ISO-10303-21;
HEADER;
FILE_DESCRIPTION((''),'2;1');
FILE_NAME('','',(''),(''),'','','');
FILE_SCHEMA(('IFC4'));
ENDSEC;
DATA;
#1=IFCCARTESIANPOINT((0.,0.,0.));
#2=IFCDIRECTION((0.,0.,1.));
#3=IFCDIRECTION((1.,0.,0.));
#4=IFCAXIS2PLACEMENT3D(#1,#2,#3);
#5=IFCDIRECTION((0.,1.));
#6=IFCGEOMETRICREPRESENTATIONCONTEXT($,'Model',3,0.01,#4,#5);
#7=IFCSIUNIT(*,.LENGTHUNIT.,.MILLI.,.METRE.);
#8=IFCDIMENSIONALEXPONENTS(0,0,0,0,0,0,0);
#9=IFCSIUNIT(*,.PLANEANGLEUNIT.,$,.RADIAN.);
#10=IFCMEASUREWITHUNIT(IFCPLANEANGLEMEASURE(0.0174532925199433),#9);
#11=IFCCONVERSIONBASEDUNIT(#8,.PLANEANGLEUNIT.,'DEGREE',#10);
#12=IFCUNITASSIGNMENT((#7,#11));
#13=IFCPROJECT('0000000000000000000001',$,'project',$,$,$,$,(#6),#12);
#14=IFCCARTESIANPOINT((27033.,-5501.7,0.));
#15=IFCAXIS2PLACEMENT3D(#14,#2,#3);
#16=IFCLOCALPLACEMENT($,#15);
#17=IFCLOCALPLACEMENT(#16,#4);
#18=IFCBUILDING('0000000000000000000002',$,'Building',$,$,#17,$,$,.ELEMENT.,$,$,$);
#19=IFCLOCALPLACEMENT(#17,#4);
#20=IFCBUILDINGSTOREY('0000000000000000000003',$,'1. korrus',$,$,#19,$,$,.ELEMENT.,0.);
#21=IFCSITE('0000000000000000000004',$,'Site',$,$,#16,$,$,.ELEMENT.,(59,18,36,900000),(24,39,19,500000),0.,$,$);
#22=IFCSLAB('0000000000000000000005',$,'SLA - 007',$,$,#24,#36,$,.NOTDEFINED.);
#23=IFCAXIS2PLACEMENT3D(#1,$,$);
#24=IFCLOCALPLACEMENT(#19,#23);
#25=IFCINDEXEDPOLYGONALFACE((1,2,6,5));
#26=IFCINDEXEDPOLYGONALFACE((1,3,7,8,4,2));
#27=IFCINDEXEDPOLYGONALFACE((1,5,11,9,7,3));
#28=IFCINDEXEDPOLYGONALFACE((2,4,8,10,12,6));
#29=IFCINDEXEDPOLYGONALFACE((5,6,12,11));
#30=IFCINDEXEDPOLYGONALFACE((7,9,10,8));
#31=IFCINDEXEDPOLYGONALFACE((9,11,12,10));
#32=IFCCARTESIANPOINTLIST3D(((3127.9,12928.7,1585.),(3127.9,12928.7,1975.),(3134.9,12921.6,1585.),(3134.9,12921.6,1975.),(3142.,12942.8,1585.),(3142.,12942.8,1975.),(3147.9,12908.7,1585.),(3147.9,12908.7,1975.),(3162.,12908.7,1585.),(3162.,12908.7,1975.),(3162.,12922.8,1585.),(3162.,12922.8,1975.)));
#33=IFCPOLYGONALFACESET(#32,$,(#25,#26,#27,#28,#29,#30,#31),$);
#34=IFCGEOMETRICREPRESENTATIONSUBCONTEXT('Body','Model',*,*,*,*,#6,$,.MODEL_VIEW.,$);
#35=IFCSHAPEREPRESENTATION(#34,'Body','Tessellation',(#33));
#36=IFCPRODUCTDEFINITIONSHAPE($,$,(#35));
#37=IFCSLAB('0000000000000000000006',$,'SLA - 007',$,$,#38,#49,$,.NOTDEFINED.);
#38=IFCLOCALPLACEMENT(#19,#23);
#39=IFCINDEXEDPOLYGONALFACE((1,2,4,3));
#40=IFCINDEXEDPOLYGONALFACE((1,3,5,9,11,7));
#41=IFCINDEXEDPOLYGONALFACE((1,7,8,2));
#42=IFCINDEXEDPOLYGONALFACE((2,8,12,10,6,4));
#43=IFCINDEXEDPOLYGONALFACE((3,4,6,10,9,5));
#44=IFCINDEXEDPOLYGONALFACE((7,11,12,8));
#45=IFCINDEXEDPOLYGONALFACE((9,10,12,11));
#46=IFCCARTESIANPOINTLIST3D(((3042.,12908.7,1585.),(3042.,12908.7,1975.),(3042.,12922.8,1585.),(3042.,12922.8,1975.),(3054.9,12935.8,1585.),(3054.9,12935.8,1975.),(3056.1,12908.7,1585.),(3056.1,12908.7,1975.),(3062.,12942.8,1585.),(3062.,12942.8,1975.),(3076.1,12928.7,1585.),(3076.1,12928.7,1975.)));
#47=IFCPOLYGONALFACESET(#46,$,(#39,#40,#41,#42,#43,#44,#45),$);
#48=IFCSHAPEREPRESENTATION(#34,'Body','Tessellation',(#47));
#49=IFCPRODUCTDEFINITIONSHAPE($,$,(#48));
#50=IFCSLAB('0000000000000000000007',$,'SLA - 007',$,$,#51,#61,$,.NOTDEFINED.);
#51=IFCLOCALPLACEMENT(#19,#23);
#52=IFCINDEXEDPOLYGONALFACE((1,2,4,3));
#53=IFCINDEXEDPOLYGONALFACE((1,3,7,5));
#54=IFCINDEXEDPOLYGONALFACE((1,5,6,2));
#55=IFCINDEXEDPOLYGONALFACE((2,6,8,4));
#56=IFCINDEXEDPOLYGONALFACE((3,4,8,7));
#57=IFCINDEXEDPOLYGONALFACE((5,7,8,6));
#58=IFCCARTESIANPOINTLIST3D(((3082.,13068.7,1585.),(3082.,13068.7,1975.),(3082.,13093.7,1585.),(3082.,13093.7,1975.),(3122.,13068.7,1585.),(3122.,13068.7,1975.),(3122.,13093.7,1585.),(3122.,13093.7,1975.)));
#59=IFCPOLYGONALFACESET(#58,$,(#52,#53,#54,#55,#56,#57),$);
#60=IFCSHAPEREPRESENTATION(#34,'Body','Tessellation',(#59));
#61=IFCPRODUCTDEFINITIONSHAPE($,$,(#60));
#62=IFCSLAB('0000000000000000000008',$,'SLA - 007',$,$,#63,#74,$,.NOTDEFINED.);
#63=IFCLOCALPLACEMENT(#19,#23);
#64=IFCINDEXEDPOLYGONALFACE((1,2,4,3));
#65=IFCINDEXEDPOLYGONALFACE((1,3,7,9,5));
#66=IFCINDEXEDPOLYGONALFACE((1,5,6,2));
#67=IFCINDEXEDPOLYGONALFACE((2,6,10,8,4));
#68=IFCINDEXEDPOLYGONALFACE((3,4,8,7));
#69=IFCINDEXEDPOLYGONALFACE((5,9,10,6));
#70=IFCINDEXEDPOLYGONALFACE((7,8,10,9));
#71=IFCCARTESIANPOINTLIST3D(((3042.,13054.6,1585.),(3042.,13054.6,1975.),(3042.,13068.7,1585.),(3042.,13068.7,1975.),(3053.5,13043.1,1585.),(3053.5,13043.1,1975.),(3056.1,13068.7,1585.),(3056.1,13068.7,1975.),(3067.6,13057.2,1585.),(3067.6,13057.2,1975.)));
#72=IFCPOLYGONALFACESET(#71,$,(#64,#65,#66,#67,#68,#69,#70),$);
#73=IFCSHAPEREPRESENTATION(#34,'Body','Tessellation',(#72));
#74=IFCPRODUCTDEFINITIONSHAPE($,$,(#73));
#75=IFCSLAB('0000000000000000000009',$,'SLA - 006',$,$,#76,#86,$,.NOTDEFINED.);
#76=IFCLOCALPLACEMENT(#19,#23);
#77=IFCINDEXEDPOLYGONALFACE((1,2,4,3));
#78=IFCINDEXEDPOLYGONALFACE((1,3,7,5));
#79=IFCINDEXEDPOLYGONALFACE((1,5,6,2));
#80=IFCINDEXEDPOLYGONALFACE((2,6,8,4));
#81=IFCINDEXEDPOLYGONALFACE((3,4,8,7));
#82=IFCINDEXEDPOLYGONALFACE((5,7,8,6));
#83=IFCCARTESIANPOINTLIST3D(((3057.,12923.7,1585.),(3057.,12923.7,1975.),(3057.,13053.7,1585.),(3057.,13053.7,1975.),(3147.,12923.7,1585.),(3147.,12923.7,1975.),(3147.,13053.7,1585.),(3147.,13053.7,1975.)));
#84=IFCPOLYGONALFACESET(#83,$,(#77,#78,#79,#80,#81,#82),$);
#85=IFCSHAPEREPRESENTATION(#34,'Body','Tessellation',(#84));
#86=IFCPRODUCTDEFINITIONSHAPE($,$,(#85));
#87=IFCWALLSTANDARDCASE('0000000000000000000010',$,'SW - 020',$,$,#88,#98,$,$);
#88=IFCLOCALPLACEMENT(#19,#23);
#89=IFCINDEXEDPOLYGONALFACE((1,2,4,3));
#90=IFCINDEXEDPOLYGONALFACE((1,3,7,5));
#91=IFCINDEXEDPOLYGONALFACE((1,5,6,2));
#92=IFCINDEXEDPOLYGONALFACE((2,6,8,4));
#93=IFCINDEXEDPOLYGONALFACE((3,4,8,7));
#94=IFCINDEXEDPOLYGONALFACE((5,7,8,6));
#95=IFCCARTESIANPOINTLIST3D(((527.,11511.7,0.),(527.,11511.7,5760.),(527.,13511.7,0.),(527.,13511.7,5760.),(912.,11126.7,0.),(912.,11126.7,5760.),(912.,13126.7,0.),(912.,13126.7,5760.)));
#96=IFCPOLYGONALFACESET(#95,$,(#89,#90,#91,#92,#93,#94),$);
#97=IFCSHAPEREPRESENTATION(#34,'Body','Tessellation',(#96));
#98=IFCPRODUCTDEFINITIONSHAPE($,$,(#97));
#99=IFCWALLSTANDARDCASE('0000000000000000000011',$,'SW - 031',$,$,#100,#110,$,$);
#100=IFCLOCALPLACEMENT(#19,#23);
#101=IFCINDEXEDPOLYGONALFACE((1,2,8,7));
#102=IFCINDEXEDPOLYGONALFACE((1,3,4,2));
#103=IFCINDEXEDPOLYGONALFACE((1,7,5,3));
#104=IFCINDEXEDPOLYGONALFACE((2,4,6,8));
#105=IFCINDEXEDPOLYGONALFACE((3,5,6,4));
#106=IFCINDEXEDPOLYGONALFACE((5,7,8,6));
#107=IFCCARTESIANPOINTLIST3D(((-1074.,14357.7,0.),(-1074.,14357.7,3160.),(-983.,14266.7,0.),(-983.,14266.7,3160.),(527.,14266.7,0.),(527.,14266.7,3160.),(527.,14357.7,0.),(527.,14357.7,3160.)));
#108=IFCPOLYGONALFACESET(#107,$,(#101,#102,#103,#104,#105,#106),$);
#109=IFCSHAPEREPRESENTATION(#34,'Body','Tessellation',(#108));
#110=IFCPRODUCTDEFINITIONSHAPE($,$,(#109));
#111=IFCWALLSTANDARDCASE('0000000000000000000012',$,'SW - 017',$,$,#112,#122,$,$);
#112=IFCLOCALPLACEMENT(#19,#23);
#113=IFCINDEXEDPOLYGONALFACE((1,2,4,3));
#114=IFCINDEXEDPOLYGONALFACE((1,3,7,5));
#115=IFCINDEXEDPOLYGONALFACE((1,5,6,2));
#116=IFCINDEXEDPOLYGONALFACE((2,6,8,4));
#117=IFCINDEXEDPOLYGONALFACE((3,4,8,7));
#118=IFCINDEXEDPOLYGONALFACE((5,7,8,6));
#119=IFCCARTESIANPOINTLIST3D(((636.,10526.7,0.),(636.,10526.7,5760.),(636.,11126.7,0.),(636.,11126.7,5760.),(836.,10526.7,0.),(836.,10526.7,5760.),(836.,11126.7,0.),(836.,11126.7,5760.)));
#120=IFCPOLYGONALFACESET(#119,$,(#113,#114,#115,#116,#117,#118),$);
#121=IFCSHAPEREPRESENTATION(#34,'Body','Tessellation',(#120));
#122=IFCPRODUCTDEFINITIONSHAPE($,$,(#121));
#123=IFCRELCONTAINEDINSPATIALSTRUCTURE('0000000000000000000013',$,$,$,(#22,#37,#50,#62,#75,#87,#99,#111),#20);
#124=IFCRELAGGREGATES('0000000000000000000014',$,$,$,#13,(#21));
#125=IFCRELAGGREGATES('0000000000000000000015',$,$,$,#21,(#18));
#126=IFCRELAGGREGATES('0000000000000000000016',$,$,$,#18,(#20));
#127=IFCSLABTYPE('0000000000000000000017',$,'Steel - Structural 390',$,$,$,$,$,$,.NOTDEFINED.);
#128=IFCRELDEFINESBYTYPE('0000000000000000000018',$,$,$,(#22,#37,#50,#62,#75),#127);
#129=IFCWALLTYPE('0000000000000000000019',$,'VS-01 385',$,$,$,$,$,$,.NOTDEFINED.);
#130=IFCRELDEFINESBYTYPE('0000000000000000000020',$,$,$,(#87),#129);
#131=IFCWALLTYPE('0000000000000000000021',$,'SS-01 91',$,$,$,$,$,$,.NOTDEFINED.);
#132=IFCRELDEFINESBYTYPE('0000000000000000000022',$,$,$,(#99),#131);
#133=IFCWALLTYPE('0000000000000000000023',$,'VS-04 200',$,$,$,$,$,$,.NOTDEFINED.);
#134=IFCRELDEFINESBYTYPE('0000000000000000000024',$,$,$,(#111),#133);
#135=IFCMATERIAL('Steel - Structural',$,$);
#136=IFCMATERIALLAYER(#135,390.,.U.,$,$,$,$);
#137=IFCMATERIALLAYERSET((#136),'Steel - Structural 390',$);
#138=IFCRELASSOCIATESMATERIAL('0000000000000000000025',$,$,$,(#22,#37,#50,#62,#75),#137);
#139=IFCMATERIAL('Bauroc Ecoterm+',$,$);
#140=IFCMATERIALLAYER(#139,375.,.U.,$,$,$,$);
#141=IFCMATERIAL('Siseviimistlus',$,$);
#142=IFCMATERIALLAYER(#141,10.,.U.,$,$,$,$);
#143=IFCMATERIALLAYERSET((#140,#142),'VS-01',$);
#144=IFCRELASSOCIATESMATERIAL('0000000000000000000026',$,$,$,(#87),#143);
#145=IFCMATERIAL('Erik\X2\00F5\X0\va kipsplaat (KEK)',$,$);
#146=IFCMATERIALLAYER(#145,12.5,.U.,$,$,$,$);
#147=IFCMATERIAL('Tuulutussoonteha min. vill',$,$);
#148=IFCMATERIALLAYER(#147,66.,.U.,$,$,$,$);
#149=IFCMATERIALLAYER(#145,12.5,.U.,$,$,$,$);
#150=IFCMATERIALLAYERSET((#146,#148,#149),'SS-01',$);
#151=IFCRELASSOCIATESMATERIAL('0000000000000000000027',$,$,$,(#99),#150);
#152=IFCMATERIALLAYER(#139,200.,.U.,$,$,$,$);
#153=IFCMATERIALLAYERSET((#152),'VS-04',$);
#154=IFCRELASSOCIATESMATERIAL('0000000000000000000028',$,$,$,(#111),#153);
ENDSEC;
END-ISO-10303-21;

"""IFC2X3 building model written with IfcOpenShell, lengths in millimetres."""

from ifc_helpers import new_model, entity, si_unit, converted_unit, direction, frame, origin_with_axes, place, context, subcontext, project, spatial, polyline, outline, extrude, material, layer, layer_set, layer_usage, type_object, element, save


model = new_model("IFC2X3")

# Units and contexts
model_context = context("Model", 3, precision=0.01, world=origin_with_axes(), true_north=direction((0.0, 1.0)))
body_context = subcontext(model_context, "Body", "Model", "MODEL_VIEW")
ifc_project = project(units=[si_unit("LENGTHUNIT", "METRE", prefix="MILLI"), converted_unit("PLANEANGLEUNIT", "DEGREE", entity("IfcPlaneAngleMeasure", 0.0174532925199433), si_unit("PLANEANGLEUNIT", "RADIAN"), dimensions=[0, 0, 0, 0, 0, 0, 0])], contexts=[model_context])

# Site, building, storey
site_placement = place(None, frame((27033.0, -5501.7, 0.0), z_axis=(0.0, 0.0, 1.0), x_axis=(1.0, 0.0, 0.0)))
site = spatial("IfcSite", under=ifc_project, at=site_placement, Name="Site", CompositionType="ELEMENT", RefLatitude=(59, 18, 36, 900000), RefLongitude=(24, 39, 19, 500000), RefElevation=0.0)
building_placement = place(site_placement, origin_with_axes())
building = spatial("IfcBuilding", under=site, at=building_placement, Name="Building", CompositionType="ELEMENT")
storey_placement = place(building_placement, origin_with_axes())
storey = spatial("IfcBuildingStorey", under=building, at=storey_placement, Name="1. korrus", CompositionType="ELEMENT", Elevation=0.0)

# Slabs
ifc_material_1 = material(Name="Steel - Structural")
ifc_layer_1 = layer(ifc_material_1, 390.0, ventilated="UNKNOWN")
ifc_layer_set_1 = layer_set([ifc_layer_1], Name="Steel - Structural 390")
ifc_layer_usage_1 = layer_usage(ifc_layer_set_1, "AXIS3", "NEGATIVE", 390.0)
slab_type = type_object("IfcSlabType", Name="Steel - Structural 390", PredefinedType="NOTDEFINED")
slab_1_placement = place(storey_placement, frame((3134.9, 12921.6, 1585.0), z_axis=(0.0, 0.0, 1.0), x_axis=(1.0, 0.0, 0.0)))
element("IfcSlab", 1, at=slab_1_placement, inside=storey, type_object=slab_type, material=ifc_layer_usage_1, Name="SLA - 007", PredefinedType="NOTDEFINED", context=body_context, shape_type="SweptSolid", body=[
    extrude(outline(polyline([(0.0, 0.0), (12.9, -12.9), (27.1, -12.9), (27.1, 1.2), (7.1, 21.2), (-7.1, 7.1), (0.0, 0.0)])), origin_with_axes(), (0.0, 0.0, 1.0), 390.0),
])
ifc_layer_usage_2 = layer_usage(ifc_layer_set_1, "AXIS3", "NEGATIVE", 390.0)
slab_2_placement = place(storey_placement, frame((3054.9, 12935.8, 1585.0), z_axis=(0.0, 0.0, 1.0), x_axis=(1.0, 0.0, 0.0)))
element("IfcSlab", 2, at=slab_2_placement, inside=storey, type_object=slab_type, material=ifc_layer_usage_2, Name="SLA - 007", PredefinedType="NOTDEFINED", context=body_context, shape_type="SweptSolid", body=[
    extrude(outline(polyline([(0.0, 0.0), (-12.9, -12.9), (-12.9, -27.1), (1.2, -27.1), (21.2, -7.1), (7.1, 7.1), (0.0, 0.0)])), origin_with_axes(), (0.0, 0.0, 1.0), 390.0),
])
ifc_layer_usage_3 = layer_usage(ifc_layer_set_1, "AXIS3", "NEGATIVE", 390.0)
slab_3_placement = place(storey_placement, frame((3082.0, 13068.7, 1585.0), z_axis=(0.0, 0.0, 1.0), x_axis=(1.0, 0.0, 0.0)))
element("IfcSlab", 3, at=slab_3_placement, inside=storey, type_object=slab_type, material=ifc_layer_usage_3, Name="SLA - 007", PredefinedType="NOTDEFINED", context=body_context, shape_type="SweptSolid", body=[
    extrude(outline(polyline([(0.0, 0.0), (40.0, 0.0), (40.0, 25.0), (0.0, 25.0), (0.0, 0.0)])), origin_with_axes(), (0.0, 0.0, 1.0), 390.0),
])
ifc_layer_usage_4 = layer_usage(ifc_layer_set_1, "AXIS3", "NEGATIVE", 390.0)
slab_4_placement = place(storey_placement, frame((3053.5, 13043.1, 1585.0), z_axis=(0.0, 0.0, 1.0), x_axis=(1.0, 0.0, 0.0)))
element("IfcSlab", 4, at=slab_4_placement, inside=storey, type_object=slab_type, material=ifc_layer_usage_4, Name="SLA - 007", PredefinedType="NOTDEFINED", context=body_context, shape_type="SweptSolid", body=[
    extrude(outline(polyline([(0.0, 0.0), (14.1, 14.1), (2.7, 25.6), (-11.5, 25.6), (-11.5, 11.5), (0.0, 0.0)])), origin_with_axes(), (0.0, 0.0, 1.0), 390.0),
])
ifc_layer_usage_5 = layer_usage(ifc_layer_set_1, "AXIS3", "NEGATIVE", 390.0)
slab_5_placement = place(storey_placement, frame((3147.0, 13053.7, 1585.0), z_axis=(0.0, 0.0, 1.0), x_axis=(1.0, 0.0, 0.0)))
element("IfcSlab", 5, at=slab_5_placement, inside=storey, type_object=slab_type, material=ifc_layer_usage_5, Name="SLA - 006", PredefinedType="NOTDEFINED", context=body_context, shape_type="SweptSolid", body=[
    extrude(outline(polyline([(0.0, 0.0), (-90.0, 0.0), (-90.0, -130.0), (0.0, -130.0), (0.0, 0.0)])), origin_with_axes(), (0.0, 0.0, 1.0), 390.0),
])

# Wall
ifc_material_2 = material(Name="Bauroc Ecoterm+")
ifc_layer_2 = layer(ifc_material_2, 375.0, ventilated="UNKNOWN")
ifc_material_3 = material(Name="Siseviimistlus")
ifc_layer_3 = layer(ifc_material_3, 10.0, ventilated="UNKNOWN")
ifc_layer_set_2 = layer_set([ifc_layer_2, ifc_layer_3], Name="VS-01")
ifc_layer_usage_6 = layer_usage(ifc_layer_set_2, "AXIS2", "POSITIVE", -385.0)
wall_type_1 = type_object("IfcWallType", Name="VS-01 385", PredefinedType="NOTDEFINED")
wall_1_placement = place(storey_placement, frame((527.0, 11511.7, 0.0), z_axis=(0.0, 0.0, 1.0), x_axis=(0.000026, 1.0, 0.0)))
element("IfcWallStandardCase", 6, at=wall_1_placement, inside=storey, type_object=wall_type_1, material=ifc_layer_usage_6, Name="SW - 020", context=body_context, shape_type="SweptSolid", body=[
    extrude(outline(polyline([(-385.0, -385.0), (1615.0, -385.0), (2000.0, 0.0), (0.0, 0.0), (-385.0, -385.0)])), origin_with_axes(), (0.0, 0.0, 1.0), 5760.0),
])

# Shared definitions
ifc_material_4 = material(Name="Erikõva kipsplaat (KEK)")
ifc_layer_4 = layer(ifc_material_4, 12.5, ventilated="UNKNOWN")
ifc_material_5 = material(Name="Tuulutussoonteha min. vill")
ifc_layer_5 = layer(ifc_material_5, 66.0, ventilated="UNKNOWN")
ifc_layer_6 = layer(ifc_material_4, 12.5, ventilated="UNKNOWN")
ifc_layer_set_3 = layer_set([ifc_layer_4, ifc_layer_5, ifc_layer_6], Name="SS-01")
wall_type_2 = type_object("IfcWallType", Name="SS-01 91", PredefinedType="NOTDEFINED")

# Wall
ifc_layer_usage_7 = layer_usage(ifc_layer_set_3, "AXIS2", "NEGATIVE", 91.0)
wall_2_placement = place(storey_placement, frame((527.0, 14357.7, 0.0), z_axis=(0.0, 0.0, 1.0), x_axis=(-1.0, 0.0, 0.0)))
element("IfcWallStandardCase", 7, at=wall_2_placement, inside=storey, type_object=wall_type_2, material=ifc_layer_usage_7, Name="SW - 031", context=body_context, shape_type="SweptSolid", body=[
    extrude(outline(polyline([(0.0, 0.0), (1601.0, 0.0), (1510.0, 91.0), (0.0, 91.0), (0.0, 0.0)])), origin_with_axes(), (0.0, 0.0, 1.0), 3160.0),
])

# Wall
ifc_layer_7 = layer(ifc_material_2, 200.0, ventilated="UNKNOWN")
ifc_layer_set_4 = layer_set([ifc_layer_7], Name="VS-04")
ifc_layer_usage_8 = layer_usage(ifc_layer_set_4, "AXIS2", "POSITIVE", 0.0)
wall_type_3 = type_object("IfcWallType", Name="VS-04 200", PredefinedType="NOTDEFINED")
wall_3_placement = place(storey_placement, frame((636.0, 11126.7, 0.0), z_axis=(0.0, 0.0, 1.0), x_axis=(0.0, -1.0, 0.0)))
element("IfcWallStandardCase", 8, at=wall_3_placement, inside=storey, type_object=wall_type_3, material=ifc_layer_usage_8, Name="SW - 017", context=body_context, shape_type="SweptSolid", body=[
    extrude(outline(polyline([(0.0, 0.0), (600.0, 0.0), (600.0, 200.0), (0.0, 200.0), (0.0, 0.0)])), origin_with_axes(), (0.0, 0.0, 1.0), 5760.0),
])

save(model, "model.ifc")
